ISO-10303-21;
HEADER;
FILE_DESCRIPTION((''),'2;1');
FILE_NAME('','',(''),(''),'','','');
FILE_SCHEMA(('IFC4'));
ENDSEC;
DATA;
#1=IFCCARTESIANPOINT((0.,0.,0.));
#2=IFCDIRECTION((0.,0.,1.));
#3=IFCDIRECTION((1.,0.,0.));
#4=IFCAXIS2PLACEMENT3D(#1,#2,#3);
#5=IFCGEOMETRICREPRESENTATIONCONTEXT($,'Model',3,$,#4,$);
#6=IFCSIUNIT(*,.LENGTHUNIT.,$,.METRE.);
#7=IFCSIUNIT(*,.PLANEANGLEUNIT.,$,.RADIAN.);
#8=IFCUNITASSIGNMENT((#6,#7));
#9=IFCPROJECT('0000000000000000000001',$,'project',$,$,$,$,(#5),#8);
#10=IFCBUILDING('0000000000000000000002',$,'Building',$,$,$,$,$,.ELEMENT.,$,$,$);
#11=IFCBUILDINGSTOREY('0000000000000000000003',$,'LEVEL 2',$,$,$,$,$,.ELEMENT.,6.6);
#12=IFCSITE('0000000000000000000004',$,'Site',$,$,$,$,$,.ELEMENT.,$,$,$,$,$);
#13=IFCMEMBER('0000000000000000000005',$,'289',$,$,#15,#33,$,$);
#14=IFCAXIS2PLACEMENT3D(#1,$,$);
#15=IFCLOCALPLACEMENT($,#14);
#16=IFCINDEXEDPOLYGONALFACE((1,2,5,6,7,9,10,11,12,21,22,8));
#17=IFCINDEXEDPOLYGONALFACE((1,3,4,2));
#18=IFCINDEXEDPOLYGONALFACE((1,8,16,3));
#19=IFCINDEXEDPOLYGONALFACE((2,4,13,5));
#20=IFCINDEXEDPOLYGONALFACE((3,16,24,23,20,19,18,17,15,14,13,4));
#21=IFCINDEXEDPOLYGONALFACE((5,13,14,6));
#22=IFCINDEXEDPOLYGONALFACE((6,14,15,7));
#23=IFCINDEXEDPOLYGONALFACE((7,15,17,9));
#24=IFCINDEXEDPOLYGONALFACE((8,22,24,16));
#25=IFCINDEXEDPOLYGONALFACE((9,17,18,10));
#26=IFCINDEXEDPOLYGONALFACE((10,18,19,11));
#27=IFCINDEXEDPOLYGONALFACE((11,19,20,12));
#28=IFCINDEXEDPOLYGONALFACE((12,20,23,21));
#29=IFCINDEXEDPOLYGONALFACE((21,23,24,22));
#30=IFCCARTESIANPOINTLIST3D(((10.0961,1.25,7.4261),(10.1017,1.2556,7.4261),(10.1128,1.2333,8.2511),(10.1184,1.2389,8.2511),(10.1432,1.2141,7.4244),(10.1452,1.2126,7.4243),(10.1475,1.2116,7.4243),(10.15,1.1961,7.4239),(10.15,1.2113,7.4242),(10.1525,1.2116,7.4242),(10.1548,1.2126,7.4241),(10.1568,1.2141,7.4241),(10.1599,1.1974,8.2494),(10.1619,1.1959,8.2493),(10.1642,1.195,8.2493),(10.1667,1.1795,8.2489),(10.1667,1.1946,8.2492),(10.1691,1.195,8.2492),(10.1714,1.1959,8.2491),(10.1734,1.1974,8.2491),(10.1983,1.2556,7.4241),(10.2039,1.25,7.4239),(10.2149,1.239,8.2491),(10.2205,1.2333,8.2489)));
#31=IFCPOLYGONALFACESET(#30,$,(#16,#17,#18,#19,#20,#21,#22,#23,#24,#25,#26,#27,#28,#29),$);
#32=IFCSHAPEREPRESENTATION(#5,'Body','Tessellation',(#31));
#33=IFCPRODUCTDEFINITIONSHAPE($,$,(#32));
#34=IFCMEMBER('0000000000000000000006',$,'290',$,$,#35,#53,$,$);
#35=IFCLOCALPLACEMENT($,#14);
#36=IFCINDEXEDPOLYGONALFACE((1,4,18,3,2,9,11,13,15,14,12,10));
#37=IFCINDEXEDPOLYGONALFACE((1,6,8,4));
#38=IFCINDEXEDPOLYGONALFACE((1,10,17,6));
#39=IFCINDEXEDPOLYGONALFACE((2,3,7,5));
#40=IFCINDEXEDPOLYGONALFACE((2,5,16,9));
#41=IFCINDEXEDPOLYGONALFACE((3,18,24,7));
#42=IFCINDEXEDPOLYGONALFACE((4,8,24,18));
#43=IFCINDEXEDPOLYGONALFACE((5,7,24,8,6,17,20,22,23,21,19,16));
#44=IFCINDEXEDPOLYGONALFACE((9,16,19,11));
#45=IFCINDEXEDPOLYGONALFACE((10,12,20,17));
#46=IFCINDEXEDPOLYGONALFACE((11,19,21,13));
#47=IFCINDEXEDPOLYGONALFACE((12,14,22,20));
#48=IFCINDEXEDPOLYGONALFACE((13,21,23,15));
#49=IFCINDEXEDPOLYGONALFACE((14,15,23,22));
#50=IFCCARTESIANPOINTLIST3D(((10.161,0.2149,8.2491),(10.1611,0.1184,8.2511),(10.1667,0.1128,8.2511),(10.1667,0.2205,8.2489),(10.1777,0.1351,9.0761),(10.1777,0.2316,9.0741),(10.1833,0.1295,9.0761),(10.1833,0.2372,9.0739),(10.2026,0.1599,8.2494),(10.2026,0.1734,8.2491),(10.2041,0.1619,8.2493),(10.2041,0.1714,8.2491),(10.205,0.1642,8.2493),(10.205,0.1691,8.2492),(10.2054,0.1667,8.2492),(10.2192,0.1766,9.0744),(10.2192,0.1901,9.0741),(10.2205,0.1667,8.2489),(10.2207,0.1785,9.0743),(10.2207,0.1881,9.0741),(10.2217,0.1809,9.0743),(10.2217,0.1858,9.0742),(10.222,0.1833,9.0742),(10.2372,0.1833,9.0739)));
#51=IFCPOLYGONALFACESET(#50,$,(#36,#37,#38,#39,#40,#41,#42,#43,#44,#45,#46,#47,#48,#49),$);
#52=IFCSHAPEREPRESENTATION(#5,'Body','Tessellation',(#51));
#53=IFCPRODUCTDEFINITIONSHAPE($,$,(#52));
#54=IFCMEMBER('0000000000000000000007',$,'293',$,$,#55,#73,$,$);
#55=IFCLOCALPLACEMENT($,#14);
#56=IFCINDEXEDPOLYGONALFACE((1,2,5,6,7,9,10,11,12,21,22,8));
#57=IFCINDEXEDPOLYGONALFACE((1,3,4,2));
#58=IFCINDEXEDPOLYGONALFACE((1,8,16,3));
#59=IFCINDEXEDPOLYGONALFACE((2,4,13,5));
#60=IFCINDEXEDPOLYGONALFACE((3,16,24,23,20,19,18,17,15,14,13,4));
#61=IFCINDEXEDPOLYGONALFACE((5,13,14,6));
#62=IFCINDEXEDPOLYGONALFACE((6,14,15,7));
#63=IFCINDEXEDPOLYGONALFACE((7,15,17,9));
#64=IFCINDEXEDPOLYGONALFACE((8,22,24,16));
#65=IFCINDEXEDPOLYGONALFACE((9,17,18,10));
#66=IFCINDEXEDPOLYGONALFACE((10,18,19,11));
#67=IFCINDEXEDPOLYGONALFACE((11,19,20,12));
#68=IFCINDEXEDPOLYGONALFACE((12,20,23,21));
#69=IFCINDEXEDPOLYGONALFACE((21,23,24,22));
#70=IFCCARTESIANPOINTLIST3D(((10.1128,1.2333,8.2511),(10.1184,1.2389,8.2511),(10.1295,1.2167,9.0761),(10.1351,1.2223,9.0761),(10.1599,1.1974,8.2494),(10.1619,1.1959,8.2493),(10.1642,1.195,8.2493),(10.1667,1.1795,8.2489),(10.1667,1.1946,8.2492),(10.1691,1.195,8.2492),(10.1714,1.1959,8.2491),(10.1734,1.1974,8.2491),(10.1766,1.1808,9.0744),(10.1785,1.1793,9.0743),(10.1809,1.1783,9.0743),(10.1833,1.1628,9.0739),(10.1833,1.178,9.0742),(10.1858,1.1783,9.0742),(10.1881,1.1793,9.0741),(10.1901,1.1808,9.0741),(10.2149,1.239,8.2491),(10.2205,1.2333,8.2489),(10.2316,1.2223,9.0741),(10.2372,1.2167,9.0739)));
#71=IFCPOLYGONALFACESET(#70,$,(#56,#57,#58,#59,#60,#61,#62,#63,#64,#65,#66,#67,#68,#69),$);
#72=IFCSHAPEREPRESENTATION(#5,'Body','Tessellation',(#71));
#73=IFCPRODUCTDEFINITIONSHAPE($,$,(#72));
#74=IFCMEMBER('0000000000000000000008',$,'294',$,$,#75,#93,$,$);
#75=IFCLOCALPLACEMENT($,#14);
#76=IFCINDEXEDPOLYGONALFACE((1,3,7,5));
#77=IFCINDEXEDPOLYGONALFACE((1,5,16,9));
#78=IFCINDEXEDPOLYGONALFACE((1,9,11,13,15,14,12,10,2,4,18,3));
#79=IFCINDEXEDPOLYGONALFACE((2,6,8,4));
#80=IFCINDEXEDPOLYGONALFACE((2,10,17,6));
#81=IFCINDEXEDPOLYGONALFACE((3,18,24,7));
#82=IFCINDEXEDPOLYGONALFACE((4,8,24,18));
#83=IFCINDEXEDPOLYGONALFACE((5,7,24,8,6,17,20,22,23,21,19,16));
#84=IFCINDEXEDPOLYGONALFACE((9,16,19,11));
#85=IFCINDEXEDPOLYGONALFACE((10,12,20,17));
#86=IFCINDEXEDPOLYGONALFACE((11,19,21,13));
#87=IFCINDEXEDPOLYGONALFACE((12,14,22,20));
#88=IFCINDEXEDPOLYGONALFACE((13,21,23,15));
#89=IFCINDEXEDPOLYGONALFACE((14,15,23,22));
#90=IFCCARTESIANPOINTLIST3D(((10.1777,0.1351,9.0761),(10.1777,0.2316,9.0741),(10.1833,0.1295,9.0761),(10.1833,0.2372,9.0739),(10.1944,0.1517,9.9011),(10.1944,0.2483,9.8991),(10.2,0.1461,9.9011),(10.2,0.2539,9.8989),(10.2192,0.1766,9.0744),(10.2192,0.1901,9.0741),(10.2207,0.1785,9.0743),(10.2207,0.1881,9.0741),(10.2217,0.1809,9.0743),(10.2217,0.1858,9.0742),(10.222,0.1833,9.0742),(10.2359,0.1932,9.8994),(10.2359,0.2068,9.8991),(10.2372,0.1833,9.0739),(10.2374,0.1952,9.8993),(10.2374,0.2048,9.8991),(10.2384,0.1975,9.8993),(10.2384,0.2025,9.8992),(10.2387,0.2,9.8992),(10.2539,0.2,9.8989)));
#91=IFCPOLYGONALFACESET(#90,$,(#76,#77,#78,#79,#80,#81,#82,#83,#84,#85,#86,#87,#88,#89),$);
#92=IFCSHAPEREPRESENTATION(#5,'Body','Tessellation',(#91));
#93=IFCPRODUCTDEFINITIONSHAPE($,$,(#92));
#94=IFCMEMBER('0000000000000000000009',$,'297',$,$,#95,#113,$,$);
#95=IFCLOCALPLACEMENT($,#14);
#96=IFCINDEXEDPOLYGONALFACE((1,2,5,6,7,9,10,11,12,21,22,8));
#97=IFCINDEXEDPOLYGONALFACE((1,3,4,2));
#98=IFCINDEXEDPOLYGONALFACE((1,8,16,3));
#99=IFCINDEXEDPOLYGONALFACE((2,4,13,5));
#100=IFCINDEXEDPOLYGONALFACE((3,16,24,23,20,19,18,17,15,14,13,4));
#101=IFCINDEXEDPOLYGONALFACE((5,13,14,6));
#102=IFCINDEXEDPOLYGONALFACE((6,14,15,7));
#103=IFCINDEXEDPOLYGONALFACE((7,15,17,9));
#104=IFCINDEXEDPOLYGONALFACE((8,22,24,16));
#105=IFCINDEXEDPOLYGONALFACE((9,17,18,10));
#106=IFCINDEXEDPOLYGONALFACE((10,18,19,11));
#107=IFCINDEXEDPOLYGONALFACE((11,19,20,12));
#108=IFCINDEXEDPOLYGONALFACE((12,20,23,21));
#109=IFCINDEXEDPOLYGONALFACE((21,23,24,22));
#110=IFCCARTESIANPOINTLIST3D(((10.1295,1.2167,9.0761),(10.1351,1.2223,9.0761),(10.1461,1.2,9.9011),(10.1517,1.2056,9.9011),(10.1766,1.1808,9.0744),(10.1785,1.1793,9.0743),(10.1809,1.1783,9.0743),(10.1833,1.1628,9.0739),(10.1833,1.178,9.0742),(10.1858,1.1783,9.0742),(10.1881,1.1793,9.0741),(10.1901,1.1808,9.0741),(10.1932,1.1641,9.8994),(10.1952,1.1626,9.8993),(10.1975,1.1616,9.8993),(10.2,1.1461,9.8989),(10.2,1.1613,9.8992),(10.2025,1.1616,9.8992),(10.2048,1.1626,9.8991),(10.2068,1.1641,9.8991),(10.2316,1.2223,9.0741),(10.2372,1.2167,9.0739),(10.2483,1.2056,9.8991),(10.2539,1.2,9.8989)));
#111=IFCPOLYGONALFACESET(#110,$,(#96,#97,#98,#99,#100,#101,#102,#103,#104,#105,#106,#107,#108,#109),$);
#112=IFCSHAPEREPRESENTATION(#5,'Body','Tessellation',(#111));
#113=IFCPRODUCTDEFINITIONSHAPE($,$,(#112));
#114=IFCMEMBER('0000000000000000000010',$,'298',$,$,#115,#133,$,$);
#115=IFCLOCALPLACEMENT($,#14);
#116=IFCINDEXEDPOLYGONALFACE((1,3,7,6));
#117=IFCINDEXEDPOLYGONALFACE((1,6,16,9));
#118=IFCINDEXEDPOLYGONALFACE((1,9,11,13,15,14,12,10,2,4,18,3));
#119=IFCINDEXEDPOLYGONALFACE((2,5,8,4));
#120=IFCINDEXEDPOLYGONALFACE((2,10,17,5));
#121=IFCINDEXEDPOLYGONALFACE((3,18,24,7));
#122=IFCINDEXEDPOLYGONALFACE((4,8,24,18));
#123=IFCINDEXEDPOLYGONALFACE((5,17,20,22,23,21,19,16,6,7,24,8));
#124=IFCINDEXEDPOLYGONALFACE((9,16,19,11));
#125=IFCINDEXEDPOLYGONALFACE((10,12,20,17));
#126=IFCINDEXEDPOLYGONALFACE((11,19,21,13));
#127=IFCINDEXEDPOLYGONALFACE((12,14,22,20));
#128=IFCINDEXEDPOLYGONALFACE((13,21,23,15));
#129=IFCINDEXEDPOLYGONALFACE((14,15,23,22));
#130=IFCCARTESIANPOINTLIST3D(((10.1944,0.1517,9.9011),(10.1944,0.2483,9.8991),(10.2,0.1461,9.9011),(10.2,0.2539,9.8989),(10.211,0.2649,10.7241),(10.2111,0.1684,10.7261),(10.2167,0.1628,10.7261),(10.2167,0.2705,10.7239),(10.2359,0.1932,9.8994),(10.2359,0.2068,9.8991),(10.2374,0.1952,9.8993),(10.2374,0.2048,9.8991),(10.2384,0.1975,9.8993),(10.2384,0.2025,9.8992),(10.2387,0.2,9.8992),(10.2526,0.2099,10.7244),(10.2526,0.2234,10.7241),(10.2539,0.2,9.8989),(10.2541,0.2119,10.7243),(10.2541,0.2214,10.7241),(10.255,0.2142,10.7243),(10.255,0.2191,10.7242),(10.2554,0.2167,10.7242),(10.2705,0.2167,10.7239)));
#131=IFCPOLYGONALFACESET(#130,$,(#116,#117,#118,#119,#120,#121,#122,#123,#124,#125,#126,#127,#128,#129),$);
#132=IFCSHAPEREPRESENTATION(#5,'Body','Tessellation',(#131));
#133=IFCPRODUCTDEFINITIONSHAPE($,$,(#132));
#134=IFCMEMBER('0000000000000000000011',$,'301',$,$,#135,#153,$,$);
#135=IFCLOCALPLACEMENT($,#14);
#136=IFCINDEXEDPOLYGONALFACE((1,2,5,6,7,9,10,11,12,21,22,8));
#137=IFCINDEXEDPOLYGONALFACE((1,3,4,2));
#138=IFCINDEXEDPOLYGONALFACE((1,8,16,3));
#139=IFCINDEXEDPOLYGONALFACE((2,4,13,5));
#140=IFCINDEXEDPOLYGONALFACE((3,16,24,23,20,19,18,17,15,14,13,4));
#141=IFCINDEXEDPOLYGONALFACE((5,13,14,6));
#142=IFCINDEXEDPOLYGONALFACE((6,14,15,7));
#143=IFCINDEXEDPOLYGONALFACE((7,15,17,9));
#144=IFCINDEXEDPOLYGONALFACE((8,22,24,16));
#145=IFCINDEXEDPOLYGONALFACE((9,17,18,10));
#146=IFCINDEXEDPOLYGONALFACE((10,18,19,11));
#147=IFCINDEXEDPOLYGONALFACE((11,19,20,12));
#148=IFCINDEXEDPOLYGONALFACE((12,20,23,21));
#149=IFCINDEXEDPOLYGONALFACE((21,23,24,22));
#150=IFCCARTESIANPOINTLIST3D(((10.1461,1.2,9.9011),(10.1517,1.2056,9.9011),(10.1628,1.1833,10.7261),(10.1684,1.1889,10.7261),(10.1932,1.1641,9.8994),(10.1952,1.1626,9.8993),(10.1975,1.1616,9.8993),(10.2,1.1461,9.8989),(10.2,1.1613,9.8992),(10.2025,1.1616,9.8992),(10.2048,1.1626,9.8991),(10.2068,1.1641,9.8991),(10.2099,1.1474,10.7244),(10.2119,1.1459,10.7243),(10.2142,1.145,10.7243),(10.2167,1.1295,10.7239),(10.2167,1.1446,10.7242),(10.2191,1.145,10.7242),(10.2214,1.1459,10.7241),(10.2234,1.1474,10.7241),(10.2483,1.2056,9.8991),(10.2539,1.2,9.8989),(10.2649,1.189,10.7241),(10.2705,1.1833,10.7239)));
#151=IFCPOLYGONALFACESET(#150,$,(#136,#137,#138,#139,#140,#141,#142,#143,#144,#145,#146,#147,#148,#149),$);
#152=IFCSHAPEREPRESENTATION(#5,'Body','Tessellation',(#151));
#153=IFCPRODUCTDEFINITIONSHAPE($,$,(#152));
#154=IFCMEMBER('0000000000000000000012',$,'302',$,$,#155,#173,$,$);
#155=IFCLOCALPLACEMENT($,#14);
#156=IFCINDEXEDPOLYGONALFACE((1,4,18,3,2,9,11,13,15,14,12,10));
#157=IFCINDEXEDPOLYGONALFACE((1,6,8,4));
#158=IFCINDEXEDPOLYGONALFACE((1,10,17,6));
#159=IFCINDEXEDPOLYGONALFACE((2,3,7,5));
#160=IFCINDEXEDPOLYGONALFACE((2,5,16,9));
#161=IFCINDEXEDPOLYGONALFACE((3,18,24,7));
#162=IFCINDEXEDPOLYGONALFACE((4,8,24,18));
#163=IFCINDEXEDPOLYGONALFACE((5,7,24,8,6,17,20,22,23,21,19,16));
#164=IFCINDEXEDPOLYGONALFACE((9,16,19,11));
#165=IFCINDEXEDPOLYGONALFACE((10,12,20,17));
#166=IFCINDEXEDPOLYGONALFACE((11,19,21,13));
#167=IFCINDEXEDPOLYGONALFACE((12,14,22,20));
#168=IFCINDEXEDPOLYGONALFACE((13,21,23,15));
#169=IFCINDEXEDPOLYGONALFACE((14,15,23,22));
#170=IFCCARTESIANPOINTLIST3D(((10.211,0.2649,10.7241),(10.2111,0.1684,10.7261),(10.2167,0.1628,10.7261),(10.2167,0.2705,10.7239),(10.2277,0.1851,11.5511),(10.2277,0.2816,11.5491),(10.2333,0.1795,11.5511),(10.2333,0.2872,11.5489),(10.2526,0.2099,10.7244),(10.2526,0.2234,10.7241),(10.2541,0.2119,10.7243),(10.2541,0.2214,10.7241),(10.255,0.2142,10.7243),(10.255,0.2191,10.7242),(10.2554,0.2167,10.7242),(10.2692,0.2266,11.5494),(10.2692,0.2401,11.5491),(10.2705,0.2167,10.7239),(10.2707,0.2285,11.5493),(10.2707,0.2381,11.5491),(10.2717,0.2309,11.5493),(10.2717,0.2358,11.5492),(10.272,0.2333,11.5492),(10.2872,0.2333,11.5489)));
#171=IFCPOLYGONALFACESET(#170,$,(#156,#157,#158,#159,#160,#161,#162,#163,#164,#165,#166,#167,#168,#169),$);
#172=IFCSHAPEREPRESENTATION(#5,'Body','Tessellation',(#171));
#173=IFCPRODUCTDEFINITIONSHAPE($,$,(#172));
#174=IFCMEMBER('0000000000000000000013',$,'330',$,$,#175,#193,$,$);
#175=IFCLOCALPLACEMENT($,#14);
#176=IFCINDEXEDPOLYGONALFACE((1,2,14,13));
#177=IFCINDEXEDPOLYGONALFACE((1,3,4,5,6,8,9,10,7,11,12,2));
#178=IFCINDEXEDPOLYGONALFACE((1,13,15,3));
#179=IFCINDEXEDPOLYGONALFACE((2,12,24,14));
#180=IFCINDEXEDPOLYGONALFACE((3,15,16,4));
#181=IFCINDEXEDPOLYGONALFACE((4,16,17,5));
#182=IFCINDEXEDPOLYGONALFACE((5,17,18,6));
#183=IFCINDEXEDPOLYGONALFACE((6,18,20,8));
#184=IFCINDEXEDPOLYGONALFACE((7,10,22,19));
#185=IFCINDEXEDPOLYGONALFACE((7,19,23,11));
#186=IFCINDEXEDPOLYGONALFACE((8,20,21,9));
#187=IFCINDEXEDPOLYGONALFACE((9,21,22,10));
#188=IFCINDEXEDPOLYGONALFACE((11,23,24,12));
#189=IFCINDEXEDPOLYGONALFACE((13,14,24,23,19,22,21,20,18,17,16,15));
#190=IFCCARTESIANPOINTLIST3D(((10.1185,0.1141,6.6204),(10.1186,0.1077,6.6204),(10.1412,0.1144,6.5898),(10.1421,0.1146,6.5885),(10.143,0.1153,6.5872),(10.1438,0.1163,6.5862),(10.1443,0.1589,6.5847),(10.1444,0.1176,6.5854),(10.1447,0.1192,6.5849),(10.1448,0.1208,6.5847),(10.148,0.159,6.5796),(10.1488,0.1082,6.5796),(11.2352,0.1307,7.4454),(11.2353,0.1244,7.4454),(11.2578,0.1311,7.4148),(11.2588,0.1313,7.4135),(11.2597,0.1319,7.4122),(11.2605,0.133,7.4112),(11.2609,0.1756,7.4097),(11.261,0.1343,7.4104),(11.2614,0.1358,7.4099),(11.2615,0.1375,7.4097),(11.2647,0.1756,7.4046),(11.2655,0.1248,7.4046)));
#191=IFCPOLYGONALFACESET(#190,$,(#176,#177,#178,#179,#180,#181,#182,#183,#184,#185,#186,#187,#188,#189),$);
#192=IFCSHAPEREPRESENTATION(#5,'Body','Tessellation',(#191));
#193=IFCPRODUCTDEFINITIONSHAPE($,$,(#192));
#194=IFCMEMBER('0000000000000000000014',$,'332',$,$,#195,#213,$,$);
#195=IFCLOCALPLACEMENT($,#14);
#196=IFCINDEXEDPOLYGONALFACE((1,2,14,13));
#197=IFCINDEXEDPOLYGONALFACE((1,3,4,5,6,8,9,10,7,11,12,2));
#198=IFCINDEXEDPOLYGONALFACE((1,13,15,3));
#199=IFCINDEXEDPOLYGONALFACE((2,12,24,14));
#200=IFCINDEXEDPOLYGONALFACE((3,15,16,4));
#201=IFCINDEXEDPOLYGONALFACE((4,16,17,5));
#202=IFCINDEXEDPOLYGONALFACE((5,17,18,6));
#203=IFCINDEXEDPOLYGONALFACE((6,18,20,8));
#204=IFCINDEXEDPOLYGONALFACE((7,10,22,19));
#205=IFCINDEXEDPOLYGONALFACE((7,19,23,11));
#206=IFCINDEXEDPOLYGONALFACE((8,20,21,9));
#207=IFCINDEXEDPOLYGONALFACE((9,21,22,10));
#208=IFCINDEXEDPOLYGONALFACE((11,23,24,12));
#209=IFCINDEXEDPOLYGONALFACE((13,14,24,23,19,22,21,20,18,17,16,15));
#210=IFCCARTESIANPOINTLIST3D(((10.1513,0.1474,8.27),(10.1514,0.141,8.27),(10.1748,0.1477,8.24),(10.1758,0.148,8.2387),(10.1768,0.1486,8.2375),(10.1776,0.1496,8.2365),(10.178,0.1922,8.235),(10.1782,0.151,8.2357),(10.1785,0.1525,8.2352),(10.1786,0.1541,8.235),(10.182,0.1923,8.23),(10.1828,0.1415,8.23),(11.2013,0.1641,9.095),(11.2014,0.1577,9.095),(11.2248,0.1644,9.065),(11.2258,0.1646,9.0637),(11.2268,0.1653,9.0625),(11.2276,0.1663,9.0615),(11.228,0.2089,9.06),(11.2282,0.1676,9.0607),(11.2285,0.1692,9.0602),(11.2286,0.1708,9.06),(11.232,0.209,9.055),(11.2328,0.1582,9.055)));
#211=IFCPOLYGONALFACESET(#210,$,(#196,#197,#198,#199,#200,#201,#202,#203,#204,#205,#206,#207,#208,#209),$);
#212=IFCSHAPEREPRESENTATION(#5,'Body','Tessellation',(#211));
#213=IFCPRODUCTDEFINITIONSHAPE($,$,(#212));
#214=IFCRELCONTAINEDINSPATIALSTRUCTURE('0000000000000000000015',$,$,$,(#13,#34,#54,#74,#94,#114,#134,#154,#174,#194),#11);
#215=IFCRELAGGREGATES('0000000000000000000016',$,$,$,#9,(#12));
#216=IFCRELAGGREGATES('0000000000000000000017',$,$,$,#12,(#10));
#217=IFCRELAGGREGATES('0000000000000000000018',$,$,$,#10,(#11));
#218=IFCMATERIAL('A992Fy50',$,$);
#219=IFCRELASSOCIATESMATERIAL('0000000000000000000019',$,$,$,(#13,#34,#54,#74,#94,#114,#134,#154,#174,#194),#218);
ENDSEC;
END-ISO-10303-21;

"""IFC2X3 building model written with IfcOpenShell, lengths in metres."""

from ifc_helpers import new_model, si_unit, frame, origin_with_axes, origin_2d_with_axis, place, context, project, spatial, l_section, extrude, material, element, save


model = new_model("IFC2X3")

# Units and contexts
model_context = context("Model", 3, world=origin_with_axes())
ifc_project = project(units=[si_unit("LENGTHUNIT", "METRE"), si_unit("PLANEANGLEUNIT", "RADIAN")], contexts=[model_context])

# Site, building, storey
site = spatial("IfcSite", under=ifc_project, Name="Site", CompositionType="ELEMENT")
building = spatial("IfcBuilding", under=site, Name="Building", CompositionType="ELEMENT")
storey = spatial("IfcBuildingStorey", under=building, Name="LEVEL 2", CompositionType="ELEMENT", Elevation=6.6)

# Shared definitions
ifc_material = material(Name="A992Fy50")

# Members
for number, where, z_axis, x_axis, name in (
    (1, (10.15, 1.25, 7.425), (0.020194, -0.020194, 0.999592), (0.707107, 0.707107, 0.0), "289"),
    (2, (10.1667, 0.1667, 8.25), (0.020194, 0.020194, 0.999592), (-0.707107, 0.707107, 0.0), "290"),
    (3, (10.1667, 1.2333, 8.25), (0.020194, -0.020194, 0.999592), (0.707107, 0.707107, 0.0), "293"),
    (4, (10.1833, 0.1833, 9.075), (0.020194, 0.020194, 0.999592), (-0.707107, 0.707107, 0.0), "294"),
    (5, (10.1833, 1.2167, 9.075), (0.020194, -0.020194, 0.999592), (0.707107, 0.707107, 0.0), "297"),
    (6, (10.2, 0.2, 9.9), (0.020194, 0.020194, 0.999592), (-0.707107, 0.707107, 0.0), "298"),
    (7, (10.2, 1.2, 9.9), (0.020194, -0.020194, 0.999592), (0.707107, 0.707107, 0.0), "301"),
    (8, (10.2167, 0.2167, 10.725), (0.020194, 0.020194, 0.999592), (-0.707107, 0.707107, 0.0), "302"),
):
    element("IfcMember", number, at=place(None, frame(where, z_axis=z_axis, x_axis=x_axis)), inside=storey, material=ifc_material, Name=name, context=model_context, shape_type="SweptSolid", body=[
        extrude(l_section(Depth=0.0762, Width=0.0762, Thickness=0.0079, FilletRadius=0.0096, at=origin_2d_with_axis()), origin_with_axes(), (0.0, 0.0, 1.0), 0.8253),
    ])
member_1_placement = place(None, frame((10.1333, 0.1333, 6.6), z_axis=(0.804243, 0.012004, 0.594179), x_axis=(-0.014924, 0.999889, 0.0)))
element("IfcMember", 9, at=member_1_placement, inside=storey, material=ifc_material, Name="330", context=model_context, shape_type="SweptSolid", body=[
    extrude(l_section(Depth=0.0508, Width=0.0508, Thickness=0.0063, FilletRadius=0.0063, at=origin_2d_with_axis()), origin_with_axes(), (0.0, 0.0, 1.0), 1.3885),
])
member_2_placement = place(None, frame((10.1667, 0.1667, 8.25), z_axis=(0.786257, 0.01248, 0.617773), x_axis=(-0.014924, 0.999889, 0.0)))
element("IfcMember", 10, at=member_2_placement, inside=storey, material=ifc_material, Name="332", context=model_context, shape_type="SweptSolid", body=[
    extrude(l_section(Depth=0.0508, Width=0.0508, Thickness=0.0063, FilletRadius=0.0063, at=origin_2d_with_axis()), origin_with_axes(), (0.0, 0.0, 1.0), 1.3354),
])

save(model, "model.ifc")
